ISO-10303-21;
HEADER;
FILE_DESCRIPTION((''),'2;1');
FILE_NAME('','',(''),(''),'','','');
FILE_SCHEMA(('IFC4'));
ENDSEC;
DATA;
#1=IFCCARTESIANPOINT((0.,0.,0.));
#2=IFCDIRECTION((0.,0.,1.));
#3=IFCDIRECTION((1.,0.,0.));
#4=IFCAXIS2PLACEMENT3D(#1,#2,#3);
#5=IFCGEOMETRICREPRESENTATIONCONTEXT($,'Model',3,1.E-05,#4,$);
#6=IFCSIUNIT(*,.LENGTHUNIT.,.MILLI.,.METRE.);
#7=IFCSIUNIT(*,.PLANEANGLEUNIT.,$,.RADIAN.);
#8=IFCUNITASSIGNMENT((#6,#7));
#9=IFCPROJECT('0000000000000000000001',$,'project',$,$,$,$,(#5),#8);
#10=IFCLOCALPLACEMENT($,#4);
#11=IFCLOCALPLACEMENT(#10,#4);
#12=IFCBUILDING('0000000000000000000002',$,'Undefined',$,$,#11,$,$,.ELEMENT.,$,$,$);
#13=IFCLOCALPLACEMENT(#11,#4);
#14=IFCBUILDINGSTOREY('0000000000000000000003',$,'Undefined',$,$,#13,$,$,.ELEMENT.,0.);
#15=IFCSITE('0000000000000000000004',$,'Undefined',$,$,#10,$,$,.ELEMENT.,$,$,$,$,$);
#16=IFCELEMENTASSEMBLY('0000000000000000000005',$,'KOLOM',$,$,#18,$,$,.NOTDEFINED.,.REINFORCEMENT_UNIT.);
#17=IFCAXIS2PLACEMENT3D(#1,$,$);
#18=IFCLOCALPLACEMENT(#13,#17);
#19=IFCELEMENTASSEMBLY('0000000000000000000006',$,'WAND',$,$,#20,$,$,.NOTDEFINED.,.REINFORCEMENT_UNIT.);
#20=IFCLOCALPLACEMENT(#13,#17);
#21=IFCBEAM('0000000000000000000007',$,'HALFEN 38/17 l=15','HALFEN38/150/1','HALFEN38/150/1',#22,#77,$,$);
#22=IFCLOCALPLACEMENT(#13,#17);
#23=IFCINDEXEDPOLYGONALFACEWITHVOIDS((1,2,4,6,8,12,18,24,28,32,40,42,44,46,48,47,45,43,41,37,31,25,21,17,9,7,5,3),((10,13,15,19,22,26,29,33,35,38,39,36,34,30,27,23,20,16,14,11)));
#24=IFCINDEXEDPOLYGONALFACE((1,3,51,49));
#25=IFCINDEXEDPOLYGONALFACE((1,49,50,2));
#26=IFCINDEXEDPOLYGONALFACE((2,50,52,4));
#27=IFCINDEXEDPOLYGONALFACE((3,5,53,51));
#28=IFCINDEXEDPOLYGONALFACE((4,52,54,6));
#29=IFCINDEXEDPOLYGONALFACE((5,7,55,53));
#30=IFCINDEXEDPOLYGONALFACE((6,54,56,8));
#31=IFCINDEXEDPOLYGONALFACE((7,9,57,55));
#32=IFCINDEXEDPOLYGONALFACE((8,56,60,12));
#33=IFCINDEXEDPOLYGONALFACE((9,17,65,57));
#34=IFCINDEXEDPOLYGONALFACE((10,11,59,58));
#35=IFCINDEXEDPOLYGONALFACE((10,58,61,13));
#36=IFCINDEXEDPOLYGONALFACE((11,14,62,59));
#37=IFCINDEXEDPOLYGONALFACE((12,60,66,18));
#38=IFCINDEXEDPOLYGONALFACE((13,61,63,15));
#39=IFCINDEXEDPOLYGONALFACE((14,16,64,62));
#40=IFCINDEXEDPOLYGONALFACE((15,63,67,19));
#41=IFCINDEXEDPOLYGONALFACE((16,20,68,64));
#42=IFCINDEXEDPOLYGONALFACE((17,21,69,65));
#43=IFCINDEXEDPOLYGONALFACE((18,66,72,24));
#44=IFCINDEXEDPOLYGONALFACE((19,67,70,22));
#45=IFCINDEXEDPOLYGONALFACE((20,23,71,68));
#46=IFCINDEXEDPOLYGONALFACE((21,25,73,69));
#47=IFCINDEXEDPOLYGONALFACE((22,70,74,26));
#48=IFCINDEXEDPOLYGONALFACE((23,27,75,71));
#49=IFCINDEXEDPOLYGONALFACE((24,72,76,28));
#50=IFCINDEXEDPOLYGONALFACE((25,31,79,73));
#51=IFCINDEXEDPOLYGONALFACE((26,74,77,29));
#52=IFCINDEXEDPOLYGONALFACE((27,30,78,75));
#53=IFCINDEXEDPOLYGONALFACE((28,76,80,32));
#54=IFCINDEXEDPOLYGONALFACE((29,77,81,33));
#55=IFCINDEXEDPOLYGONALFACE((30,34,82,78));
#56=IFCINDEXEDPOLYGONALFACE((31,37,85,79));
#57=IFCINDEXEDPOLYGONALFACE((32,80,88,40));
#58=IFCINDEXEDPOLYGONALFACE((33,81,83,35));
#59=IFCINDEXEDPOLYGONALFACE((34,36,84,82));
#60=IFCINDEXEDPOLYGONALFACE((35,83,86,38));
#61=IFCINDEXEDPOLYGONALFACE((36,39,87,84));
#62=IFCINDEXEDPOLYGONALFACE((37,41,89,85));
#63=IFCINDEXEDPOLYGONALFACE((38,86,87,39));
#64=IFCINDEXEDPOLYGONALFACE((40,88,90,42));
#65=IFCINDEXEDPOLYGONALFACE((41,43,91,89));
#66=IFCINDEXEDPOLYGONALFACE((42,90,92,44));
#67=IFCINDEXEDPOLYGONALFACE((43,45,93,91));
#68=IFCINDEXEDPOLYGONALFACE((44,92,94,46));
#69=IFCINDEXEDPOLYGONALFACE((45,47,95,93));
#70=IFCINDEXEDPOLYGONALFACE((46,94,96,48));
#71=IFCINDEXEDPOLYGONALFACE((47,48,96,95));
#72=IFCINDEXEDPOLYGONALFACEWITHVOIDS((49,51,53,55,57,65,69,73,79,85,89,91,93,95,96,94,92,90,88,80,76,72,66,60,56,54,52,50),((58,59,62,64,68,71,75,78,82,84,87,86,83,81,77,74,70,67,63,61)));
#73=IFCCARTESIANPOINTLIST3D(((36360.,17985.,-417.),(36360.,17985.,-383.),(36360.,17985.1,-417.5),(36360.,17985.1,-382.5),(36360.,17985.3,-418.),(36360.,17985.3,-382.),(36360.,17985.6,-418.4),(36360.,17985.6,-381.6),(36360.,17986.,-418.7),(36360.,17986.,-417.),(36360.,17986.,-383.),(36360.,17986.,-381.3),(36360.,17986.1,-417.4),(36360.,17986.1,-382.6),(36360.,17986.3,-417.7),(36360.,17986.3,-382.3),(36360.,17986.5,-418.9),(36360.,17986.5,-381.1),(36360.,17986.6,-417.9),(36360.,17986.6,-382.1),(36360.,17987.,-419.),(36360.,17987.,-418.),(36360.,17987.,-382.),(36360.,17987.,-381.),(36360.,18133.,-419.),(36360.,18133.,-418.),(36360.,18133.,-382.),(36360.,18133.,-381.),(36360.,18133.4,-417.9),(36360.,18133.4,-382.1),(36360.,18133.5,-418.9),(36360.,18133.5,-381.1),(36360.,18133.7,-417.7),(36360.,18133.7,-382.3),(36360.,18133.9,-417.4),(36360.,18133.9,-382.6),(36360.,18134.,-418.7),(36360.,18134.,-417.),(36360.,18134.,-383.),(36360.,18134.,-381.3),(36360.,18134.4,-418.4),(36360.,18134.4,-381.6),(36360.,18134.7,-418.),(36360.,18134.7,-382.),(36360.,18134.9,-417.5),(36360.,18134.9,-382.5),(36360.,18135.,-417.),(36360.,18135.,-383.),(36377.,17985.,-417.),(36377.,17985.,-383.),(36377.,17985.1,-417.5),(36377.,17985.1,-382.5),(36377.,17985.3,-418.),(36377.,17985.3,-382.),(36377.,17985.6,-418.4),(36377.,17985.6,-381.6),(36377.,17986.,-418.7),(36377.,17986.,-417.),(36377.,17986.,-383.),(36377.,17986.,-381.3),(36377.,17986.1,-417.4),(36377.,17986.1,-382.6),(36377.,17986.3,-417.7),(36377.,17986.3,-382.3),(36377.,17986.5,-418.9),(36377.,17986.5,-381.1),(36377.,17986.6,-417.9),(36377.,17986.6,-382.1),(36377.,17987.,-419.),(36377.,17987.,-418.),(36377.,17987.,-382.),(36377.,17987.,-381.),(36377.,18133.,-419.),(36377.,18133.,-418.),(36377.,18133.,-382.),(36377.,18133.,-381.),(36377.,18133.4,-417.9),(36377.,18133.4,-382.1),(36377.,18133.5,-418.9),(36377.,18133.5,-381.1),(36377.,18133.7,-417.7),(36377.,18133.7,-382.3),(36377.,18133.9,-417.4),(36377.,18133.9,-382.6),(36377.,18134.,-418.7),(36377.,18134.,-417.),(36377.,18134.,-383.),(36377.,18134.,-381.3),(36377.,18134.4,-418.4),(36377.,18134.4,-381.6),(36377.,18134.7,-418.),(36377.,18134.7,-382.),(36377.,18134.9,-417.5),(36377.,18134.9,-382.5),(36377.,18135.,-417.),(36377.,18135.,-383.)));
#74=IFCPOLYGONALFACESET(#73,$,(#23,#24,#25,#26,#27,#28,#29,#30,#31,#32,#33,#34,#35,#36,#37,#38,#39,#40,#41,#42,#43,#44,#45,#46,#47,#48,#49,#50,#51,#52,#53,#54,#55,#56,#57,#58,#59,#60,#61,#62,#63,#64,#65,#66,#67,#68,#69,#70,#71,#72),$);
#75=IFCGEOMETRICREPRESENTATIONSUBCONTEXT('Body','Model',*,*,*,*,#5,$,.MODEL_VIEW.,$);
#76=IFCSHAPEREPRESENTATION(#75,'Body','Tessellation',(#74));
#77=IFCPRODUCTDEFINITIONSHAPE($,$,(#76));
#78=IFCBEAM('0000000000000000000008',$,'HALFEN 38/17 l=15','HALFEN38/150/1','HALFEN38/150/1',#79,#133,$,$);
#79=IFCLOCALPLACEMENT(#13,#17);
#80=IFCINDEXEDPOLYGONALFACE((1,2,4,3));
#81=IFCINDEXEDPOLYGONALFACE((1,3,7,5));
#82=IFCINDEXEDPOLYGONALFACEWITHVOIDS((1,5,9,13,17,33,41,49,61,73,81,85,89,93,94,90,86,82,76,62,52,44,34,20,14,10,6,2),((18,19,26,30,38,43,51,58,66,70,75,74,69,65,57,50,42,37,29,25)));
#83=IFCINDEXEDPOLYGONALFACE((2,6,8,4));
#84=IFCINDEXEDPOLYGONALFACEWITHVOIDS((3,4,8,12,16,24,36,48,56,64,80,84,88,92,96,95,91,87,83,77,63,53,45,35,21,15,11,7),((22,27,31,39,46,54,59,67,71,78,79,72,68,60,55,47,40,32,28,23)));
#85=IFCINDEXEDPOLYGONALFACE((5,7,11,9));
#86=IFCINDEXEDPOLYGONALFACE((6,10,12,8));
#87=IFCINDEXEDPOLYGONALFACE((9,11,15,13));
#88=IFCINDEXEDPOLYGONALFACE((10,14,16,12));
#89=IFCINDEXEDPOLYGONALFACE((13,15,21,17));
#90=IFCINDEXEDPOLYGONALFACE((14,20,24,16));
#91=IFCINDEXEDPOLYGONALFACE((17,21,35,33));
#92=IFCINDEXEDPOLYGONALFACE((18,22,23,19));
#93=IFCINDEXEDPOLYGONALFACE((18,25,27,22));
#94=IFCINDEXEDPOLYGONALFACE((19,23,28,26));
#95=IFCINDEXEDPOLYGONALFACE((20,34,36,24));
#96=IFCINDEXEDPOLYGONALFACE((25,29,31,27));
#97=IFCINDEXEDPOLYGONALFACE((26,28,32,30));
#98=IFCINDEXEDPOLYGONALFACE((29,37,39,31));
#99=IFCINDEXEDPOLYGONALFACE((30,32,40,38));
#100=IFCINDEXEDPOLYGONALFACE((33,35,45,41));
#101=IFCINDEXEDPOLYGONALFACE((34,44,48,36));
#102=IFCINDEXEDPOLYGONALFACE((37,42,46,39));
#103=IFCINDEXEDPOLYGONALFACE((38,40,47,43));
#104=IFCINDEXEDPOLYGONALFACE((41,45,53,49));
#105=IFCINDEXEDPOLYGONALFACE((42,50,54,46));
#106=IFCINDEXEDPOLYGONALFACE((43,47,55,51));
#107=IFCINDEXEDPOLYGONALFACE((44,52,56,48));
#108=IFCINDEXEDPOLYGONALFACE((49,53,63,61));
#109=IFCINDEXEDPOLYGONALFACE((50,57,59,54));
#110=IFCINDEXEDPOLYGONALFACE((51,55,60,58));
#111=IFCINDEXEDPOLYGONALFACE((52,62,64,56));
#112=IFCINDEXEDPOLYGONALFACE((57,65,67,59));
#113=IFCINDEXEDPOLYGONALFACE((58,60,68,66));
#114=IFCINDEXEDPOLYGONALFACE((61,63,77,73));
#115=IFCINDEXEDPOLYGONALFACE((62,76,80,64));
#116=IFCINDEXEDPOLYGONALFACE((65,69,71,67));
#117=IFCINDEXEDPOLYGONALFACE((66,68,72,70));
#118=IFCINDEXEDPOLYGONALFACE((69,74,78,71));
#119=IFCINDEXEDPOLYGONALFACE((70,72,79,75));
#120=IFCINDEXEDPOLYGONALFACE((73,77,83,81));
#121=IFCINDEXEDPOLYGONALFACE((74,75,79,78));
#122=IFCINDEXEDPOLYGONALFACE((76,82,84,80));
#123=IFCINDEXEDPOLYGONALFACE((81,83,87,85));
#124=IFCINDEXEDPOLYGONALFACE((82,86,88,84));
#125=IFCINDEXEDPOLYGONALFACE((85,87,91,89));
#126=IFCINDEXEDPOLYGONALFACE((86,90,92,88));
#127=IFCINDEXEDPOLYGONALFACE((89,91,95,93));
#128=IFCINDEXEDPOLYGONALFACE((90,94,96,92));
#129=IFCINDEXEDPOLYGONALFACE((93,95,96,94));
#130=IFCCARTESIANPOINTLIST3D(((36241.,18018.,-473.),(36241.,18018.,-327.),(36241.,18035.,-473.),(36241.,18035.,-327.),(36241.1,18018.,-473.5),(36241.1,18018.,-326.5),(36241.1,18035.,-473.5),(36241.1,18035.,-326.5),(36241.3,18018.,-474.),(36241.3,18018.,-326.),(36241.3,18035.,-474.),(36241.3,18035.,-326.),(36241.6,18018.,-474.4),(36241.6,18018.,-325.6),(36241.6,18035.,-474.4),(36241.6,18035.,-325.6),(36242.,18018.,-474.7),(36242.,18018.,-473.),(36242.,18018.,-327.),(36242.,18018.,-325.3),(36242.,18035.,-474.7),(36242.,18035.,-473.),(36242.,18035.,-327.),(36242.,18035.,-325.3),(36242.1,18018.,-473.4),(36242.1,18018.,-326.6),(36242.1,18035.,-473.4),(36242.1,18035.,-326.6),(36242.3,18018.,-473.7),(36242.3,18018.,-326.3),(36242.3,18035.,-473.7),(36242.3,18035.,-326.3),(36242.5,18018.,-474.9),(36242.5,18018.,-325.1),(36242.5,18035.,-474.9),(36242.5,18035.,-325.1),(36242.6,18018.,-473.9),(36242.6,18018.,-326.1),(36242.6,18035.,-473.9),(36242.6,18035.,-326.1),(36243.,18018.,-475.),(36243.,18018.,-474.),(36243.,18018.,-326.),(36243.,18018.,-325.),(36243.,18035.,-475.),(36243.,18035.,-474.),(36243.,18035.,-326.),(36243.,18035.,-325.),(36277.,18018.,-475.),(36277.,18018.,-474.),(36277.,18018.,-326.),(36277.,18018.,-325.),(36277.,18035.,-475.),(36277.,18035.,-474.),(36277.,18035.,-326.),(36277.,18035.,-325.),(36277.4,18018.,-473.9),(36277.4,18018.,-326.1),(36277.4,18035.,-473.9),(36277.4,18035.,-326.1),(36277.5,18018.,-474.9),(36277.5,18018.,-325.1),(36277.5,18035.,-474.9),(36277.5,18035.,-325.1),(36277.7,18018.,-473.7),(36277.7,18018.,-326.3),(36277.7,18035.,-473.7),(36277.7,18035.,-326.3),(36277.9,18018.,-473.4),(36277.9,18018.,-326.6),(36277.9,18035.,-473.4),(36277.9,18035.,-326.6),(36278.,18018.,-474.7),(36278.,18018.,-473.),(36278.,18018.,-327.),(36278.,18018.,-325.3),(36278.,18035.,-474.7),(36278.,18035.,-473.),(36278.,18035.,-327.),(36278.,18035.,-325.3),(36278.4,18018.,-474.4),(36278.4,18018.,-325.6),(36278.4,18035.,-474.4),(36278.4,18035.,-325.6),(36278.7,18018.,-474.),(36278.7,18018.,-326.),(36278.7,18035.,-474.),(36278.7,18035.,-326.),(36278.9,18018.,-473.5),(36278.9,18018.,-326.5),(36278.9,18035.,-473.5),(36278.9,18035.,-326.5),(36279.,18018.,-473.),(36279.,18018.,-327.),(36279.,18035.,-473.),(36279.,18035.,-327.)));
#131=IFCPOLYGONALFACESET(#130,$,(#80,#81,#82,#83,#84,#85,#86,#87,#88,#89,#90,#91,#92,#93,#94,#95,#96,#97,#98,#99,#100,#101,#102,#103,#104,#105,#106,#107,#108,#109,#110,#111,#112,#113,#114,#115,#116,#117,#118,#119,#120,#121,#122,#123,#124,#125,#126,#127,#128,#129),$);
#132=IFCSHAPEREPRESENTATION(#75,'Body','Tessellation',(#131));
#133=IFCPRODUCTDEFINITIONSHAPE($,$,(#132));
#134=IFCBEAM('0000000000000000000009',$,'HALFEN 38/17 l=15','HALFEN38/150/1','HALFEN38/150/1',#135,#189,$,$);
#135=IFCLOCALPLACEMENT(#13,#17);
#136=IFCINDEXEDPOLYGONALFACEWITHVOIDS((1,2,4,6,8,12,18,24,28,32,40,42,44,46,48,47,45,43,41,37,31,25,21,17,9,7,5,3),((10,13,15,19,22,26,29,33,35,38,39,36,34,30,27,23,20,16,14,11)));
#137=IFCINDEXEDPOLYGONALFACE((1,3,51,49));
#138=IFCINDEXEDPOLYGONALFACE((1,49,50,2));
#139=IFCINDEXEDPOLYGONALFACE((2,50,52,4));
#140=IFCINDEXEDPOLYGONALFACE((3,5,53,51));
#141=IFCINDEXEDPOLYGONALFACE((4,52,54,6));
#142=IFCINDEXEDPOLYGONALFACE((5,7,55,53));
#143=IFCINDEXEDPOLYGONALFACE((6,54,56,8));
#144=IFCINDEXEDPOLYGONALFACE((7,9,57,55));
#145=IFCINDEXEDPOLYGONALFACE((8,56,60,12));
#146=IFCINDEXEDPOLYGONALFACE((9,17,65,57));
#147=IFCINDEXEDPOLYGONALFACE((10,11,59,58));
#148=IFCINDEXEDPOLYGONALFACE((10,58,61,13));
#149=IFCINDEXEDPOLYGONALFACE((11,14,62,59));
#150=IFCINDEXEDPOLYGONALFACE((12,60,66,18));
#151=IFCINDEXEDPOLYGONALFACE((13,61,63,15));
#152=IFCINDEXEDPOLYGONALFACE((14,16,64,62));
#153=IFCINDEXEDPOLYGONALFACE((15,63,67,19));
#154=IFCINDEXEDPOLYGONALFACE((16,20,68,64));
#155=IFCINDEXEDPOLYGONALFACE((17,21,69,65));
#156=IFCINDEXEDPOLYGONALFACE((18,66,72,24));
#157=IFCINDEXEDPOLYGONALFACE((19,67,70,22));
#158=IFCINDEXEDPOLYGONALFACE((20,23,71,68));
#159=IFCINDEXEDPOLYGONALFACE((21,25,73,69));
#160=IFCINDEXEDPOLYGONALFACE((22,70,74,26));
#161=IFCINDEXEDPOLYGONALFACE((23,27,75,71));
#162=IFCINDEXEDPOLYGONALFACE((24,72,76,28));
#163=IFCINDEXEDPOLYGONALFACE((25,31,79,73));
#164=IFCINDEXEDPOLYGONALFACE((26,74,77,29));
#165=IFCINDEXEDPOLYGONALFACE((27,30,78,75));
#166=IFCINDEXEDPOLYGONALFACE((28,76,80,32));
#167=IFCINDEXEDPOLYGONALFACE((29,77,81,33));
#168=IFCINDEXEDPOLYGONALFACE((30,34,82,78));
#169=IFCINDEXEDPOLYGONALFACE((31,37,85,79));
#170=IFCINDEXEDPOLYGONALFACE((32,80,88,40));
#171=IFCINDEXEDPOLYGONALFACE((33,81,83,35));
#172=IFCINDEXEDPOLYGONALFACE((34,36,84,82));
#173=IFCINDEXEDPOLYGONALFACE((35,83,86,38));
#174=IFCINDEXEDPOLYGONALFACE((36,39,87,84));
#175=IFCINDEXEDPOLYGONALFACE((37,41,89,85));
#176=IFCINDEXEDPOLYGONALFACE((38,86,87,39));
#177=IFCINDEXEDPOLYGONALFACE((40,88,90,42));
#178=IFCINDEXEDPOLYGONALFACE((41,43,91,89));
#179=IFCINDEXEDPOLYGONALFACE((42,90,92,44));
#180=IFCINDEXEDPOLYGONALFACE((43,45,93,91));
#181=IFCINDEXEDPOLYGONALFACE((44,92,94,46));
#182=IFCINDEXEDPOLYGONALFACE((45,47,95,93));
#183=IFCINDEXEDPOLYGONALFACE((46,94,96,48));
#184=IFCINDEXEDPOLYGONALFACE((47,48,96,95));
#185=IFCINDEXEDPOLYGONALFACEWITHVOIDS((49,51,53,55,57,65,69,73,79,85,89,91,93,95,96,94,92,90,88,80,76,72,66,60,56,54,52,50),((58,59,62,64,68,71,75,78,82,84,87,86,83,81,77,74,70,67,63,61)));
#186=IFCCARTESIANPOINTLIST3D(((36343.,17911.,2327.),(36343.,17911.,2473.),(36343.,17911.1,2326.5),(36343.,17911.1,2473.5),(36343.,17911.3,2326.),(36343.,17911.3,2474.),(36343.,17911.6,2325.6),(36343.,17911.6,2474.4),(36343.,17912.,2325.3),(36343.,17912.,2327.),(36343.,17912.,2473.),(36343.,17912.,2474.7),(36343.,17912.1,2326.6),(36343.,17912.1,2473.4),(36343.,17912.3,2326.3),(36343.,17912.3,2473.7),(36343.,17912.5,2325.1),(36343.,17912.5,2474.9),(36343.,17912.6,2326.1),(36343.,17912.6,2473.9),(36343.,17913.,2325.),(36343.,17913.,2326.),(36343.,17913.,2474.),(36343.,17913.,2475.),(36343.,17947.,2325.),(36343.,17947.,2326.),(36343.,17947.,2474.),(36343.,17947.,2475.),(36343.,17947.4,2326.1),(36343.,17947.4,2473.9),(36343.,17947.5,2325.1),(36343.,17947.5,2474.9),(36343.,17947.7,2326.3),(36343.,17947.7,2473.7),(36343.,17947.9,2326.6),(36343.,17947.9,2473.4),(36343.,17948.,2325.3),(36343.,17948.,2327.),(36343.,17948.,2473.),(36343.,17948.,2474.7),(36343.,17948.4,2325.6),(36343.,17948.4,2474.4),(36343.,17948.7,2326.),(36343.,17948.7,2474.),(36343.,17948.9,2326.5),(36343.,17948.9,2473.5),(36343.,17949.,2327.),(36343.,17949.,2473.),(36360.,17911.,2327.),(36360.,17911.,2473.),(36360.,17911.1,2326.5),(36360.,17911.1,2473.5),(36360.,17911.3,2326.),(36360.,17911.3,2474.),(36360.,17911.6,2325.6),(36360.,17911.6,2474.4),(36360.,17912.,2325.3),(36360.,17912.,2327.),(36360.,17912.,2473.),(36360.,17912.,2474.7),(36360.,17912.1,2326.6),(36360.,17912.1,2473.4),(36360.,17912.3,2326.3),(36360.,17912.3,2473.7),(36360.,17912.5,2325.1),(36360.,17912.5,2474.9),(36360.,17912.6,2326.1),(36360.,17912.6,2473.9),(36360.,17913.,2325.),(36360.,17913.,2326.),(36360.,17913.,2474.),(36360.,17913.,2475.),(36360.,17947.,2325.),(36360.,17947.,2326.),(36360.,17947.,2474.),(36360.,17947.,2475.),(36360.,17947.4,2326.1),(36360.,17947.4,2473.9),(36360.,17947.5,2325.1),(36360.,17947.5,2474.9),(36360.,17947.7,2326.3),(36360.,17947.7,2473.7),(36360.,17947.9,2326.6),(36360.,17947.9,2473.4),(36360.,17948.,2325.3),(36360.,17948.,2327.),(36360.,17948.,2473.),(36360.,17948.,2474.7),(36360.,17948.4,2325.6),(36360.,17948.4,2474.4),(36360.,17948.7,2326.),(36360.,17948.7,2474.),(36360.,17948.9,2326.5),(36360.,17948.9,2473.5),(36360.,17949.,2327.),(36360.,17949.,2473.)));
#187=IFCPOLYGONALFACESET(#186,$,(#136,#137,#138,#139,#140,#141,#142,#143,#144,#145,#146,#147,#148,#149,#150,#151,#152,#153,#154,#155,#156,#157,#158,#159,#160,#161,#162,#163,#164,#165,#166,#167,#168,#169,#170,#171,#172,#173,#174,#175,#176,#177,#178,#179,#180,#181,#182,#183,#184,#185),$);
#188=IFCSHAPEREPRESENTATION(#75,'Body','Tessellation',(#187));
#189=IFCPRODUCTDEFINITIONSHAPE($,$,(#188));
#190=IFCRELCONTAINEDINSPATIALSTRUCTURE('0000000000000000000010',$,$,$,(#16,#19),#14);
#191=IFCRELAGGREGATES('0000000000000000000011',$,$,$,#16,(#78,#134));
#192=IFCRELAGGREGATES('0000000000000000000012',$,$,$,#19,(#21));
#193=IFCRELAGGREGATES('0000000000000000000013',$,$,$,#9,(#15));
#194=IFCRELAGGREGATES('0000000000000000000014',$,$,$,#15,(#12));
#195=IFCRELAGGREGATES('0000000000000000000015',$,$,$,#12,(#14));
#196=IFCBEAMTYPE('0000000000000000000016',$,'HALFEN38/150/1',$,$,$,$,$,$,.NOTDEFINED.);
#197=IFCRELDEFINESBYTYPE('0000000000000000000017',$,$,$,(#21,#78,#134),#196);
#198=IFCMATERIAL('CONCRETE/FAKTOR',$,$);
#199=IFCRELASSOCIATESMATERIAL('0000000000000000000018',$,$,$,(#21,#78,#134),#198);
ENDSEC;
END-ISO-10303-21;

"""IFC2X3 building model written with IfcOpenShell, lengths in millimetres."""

from ifc_helpers import new_model, si_unit, frame, frame_2d, origin_with_axes, place, context, subcontext, project, spatial, hollow_rectangle, extrude, material, type_object, element, aggregate, save


model = new_model("IFC2X3")

# Units and contexts
model_context = context("Model", 3, precision=1e-05, world=origin_with_axes())
body_context = subcontext(model_context, "Body", "Model", "MODEL_VIEW")
ifc_project = project(units=[si_unit("LENGTHUNIT", "METRE", prefix="MILLI"), si_unit("PLANEANGLEUNIT", "RADIAN")], contexts=[model_context])

# Site, building, storey
site_placement = place(None, origin_with_axes())
site = spatial("IfcSite", under=ifc_project, at=site_placement, Name="Undefined", CompositionType="ELEMENT")
building_placement = place(site_placement, origin_with_axes())
building = spatial("IfcBuilding", under=site, at=building_placement, Name="Undefined", CompositionType="ELEMENT")
storey_placement = place(building_placement, origin_with_axes())
storey = spatial("IfcBuildingStorey", under=building, at=storey_placement, Name="Undefined", CompositionType="ELEMENT", Elevation=0.0)

# Element assemblies
ifc_material_1 = material(Name="CONCRETE/FAKTOR")
beam_type_1 = type_object("IfcBeamType", Name="HALFEN38/150/1", PredefinedType="NOTDEFINED")
assembly_1_placement = place(storey_placement, origin_with_axes())
assembly_1 = element("IfcElementAssembly", 1, at=assembly_1_placement, inside=storey, Name="KOLOM", AssemblyPlace="NOTDEFINED", PredefinedType="REINFORCEMENT_UNIT")
assembly_2_placement = place(storey_placement, origin_with_axes())
assembly_2 = element("IfcElementAssembly", 2, at=assembly_2_placement, inside=storey, Name="WAND", AssemblyPlace="NOTDEFINED", PredefinedType="REINFORCEMENT_UNIT")

# Beams
beam_1_placement = place(assembly_2_placement, frame((36360.0, 18060.0, -400.0), z_axis=(0.0, 0.0, -1.0), x_axis=(1.0, 0.0, 0.0)))
beam_1 = element("IfcBeam", 3, at=beam_1_placement, type_object=beam_type_1, material=ifc_material_1, Name="HALFEN 38/17 l=15", Description="HALFEN38/150/1", ObjectType="HALFEN38/150/1", context=body_context, shape_type="SweptSolid", body=[
    extrude(hollow_rectangle(XDim=150.0, YDim=38.0, WallThickness=1.0, InnerFilletRadius=1.0, OuterFilletRadius=2.0, at=frame_2d((0.0, 0.0), x_axis=(1.0, 0.0))), frame((17.0, 0.0, 0.0), z_axis=(-1.0, 0.0, 0.0), x_axis=(0.0, -1.0, 0.0)), (0.0, 0.0, 1.0), 17.0),
])
beam_2_placement = place(assembly_1_placement, frame((36260.0, 18035.0, -400.0), z_axis=(-1.0, 0.0, 0.0), x_axis=(0.0, -1.0, 0.0)))
beam_2 = element("IfcBeam", 4, at=beam_2_placement, type_object=beam_type_1, material=ifc_material_1, Name="HALFEN 38/17 l=15", Description="HALFEN38/150/1", ObjectType="HALFEN38/150/1", context=body_context, shape_type="SweptSolid", body=[
    extrude(hollow_rectangle(XDim=150.0, YDim=38.0, WallThickness=1.0, InnerFilletRadius=1.0, OuterFilletRadius=2.0, at=frame_2d((0.0, 0.0), x_axis=(1.0, 0.0))), frame((17.0, 0.0, 0.0), z_axis=(-1.0, 0.0, 0.0), x_axis=(0.0, -1.0, 0.0)), (0.0, 0.0, 1.0), 17.0),
])
beam_3_placement = place(assembly_1_placement, frame((36360.0, 17930.0, 2400.0), z_axis=(0.0, 1.0, 0.0), x_axis=(-1.0, 0.0, 0.0)))
beam_3 = element("IfcBeam", 5, at=beam_3_placement, type_object=beam_type_1, material=ifc_material_1, Name="HALFEN 38/17 l=15", Description="HALFEN38/150/1", ObjectType="HALFEN38/150/1", context=body_context, shape_type="SweptSolid", body=[
    extrude(hollow_rectangle(XDim=150.0, YDim=38.0, WallThickness=1.0, InnerFilletRadius=1.0, OuterFilletRadius=2.0, at=frame_2d((0.0, 0.0), x_axis=(1.0, 0.0))), frame((17.0, 0.0, 0.0), z_axis=(-1.0, 0.0, 0.0), x_axis=(0.0, -1.0, 0.0)), (0.0, 0.0, 1.0), 17.0),
])
aggregate(assembly_1, [beam_2, beam_3])

aggregate(assembly_2, [beam_1])

save(model, "model.ifc")
